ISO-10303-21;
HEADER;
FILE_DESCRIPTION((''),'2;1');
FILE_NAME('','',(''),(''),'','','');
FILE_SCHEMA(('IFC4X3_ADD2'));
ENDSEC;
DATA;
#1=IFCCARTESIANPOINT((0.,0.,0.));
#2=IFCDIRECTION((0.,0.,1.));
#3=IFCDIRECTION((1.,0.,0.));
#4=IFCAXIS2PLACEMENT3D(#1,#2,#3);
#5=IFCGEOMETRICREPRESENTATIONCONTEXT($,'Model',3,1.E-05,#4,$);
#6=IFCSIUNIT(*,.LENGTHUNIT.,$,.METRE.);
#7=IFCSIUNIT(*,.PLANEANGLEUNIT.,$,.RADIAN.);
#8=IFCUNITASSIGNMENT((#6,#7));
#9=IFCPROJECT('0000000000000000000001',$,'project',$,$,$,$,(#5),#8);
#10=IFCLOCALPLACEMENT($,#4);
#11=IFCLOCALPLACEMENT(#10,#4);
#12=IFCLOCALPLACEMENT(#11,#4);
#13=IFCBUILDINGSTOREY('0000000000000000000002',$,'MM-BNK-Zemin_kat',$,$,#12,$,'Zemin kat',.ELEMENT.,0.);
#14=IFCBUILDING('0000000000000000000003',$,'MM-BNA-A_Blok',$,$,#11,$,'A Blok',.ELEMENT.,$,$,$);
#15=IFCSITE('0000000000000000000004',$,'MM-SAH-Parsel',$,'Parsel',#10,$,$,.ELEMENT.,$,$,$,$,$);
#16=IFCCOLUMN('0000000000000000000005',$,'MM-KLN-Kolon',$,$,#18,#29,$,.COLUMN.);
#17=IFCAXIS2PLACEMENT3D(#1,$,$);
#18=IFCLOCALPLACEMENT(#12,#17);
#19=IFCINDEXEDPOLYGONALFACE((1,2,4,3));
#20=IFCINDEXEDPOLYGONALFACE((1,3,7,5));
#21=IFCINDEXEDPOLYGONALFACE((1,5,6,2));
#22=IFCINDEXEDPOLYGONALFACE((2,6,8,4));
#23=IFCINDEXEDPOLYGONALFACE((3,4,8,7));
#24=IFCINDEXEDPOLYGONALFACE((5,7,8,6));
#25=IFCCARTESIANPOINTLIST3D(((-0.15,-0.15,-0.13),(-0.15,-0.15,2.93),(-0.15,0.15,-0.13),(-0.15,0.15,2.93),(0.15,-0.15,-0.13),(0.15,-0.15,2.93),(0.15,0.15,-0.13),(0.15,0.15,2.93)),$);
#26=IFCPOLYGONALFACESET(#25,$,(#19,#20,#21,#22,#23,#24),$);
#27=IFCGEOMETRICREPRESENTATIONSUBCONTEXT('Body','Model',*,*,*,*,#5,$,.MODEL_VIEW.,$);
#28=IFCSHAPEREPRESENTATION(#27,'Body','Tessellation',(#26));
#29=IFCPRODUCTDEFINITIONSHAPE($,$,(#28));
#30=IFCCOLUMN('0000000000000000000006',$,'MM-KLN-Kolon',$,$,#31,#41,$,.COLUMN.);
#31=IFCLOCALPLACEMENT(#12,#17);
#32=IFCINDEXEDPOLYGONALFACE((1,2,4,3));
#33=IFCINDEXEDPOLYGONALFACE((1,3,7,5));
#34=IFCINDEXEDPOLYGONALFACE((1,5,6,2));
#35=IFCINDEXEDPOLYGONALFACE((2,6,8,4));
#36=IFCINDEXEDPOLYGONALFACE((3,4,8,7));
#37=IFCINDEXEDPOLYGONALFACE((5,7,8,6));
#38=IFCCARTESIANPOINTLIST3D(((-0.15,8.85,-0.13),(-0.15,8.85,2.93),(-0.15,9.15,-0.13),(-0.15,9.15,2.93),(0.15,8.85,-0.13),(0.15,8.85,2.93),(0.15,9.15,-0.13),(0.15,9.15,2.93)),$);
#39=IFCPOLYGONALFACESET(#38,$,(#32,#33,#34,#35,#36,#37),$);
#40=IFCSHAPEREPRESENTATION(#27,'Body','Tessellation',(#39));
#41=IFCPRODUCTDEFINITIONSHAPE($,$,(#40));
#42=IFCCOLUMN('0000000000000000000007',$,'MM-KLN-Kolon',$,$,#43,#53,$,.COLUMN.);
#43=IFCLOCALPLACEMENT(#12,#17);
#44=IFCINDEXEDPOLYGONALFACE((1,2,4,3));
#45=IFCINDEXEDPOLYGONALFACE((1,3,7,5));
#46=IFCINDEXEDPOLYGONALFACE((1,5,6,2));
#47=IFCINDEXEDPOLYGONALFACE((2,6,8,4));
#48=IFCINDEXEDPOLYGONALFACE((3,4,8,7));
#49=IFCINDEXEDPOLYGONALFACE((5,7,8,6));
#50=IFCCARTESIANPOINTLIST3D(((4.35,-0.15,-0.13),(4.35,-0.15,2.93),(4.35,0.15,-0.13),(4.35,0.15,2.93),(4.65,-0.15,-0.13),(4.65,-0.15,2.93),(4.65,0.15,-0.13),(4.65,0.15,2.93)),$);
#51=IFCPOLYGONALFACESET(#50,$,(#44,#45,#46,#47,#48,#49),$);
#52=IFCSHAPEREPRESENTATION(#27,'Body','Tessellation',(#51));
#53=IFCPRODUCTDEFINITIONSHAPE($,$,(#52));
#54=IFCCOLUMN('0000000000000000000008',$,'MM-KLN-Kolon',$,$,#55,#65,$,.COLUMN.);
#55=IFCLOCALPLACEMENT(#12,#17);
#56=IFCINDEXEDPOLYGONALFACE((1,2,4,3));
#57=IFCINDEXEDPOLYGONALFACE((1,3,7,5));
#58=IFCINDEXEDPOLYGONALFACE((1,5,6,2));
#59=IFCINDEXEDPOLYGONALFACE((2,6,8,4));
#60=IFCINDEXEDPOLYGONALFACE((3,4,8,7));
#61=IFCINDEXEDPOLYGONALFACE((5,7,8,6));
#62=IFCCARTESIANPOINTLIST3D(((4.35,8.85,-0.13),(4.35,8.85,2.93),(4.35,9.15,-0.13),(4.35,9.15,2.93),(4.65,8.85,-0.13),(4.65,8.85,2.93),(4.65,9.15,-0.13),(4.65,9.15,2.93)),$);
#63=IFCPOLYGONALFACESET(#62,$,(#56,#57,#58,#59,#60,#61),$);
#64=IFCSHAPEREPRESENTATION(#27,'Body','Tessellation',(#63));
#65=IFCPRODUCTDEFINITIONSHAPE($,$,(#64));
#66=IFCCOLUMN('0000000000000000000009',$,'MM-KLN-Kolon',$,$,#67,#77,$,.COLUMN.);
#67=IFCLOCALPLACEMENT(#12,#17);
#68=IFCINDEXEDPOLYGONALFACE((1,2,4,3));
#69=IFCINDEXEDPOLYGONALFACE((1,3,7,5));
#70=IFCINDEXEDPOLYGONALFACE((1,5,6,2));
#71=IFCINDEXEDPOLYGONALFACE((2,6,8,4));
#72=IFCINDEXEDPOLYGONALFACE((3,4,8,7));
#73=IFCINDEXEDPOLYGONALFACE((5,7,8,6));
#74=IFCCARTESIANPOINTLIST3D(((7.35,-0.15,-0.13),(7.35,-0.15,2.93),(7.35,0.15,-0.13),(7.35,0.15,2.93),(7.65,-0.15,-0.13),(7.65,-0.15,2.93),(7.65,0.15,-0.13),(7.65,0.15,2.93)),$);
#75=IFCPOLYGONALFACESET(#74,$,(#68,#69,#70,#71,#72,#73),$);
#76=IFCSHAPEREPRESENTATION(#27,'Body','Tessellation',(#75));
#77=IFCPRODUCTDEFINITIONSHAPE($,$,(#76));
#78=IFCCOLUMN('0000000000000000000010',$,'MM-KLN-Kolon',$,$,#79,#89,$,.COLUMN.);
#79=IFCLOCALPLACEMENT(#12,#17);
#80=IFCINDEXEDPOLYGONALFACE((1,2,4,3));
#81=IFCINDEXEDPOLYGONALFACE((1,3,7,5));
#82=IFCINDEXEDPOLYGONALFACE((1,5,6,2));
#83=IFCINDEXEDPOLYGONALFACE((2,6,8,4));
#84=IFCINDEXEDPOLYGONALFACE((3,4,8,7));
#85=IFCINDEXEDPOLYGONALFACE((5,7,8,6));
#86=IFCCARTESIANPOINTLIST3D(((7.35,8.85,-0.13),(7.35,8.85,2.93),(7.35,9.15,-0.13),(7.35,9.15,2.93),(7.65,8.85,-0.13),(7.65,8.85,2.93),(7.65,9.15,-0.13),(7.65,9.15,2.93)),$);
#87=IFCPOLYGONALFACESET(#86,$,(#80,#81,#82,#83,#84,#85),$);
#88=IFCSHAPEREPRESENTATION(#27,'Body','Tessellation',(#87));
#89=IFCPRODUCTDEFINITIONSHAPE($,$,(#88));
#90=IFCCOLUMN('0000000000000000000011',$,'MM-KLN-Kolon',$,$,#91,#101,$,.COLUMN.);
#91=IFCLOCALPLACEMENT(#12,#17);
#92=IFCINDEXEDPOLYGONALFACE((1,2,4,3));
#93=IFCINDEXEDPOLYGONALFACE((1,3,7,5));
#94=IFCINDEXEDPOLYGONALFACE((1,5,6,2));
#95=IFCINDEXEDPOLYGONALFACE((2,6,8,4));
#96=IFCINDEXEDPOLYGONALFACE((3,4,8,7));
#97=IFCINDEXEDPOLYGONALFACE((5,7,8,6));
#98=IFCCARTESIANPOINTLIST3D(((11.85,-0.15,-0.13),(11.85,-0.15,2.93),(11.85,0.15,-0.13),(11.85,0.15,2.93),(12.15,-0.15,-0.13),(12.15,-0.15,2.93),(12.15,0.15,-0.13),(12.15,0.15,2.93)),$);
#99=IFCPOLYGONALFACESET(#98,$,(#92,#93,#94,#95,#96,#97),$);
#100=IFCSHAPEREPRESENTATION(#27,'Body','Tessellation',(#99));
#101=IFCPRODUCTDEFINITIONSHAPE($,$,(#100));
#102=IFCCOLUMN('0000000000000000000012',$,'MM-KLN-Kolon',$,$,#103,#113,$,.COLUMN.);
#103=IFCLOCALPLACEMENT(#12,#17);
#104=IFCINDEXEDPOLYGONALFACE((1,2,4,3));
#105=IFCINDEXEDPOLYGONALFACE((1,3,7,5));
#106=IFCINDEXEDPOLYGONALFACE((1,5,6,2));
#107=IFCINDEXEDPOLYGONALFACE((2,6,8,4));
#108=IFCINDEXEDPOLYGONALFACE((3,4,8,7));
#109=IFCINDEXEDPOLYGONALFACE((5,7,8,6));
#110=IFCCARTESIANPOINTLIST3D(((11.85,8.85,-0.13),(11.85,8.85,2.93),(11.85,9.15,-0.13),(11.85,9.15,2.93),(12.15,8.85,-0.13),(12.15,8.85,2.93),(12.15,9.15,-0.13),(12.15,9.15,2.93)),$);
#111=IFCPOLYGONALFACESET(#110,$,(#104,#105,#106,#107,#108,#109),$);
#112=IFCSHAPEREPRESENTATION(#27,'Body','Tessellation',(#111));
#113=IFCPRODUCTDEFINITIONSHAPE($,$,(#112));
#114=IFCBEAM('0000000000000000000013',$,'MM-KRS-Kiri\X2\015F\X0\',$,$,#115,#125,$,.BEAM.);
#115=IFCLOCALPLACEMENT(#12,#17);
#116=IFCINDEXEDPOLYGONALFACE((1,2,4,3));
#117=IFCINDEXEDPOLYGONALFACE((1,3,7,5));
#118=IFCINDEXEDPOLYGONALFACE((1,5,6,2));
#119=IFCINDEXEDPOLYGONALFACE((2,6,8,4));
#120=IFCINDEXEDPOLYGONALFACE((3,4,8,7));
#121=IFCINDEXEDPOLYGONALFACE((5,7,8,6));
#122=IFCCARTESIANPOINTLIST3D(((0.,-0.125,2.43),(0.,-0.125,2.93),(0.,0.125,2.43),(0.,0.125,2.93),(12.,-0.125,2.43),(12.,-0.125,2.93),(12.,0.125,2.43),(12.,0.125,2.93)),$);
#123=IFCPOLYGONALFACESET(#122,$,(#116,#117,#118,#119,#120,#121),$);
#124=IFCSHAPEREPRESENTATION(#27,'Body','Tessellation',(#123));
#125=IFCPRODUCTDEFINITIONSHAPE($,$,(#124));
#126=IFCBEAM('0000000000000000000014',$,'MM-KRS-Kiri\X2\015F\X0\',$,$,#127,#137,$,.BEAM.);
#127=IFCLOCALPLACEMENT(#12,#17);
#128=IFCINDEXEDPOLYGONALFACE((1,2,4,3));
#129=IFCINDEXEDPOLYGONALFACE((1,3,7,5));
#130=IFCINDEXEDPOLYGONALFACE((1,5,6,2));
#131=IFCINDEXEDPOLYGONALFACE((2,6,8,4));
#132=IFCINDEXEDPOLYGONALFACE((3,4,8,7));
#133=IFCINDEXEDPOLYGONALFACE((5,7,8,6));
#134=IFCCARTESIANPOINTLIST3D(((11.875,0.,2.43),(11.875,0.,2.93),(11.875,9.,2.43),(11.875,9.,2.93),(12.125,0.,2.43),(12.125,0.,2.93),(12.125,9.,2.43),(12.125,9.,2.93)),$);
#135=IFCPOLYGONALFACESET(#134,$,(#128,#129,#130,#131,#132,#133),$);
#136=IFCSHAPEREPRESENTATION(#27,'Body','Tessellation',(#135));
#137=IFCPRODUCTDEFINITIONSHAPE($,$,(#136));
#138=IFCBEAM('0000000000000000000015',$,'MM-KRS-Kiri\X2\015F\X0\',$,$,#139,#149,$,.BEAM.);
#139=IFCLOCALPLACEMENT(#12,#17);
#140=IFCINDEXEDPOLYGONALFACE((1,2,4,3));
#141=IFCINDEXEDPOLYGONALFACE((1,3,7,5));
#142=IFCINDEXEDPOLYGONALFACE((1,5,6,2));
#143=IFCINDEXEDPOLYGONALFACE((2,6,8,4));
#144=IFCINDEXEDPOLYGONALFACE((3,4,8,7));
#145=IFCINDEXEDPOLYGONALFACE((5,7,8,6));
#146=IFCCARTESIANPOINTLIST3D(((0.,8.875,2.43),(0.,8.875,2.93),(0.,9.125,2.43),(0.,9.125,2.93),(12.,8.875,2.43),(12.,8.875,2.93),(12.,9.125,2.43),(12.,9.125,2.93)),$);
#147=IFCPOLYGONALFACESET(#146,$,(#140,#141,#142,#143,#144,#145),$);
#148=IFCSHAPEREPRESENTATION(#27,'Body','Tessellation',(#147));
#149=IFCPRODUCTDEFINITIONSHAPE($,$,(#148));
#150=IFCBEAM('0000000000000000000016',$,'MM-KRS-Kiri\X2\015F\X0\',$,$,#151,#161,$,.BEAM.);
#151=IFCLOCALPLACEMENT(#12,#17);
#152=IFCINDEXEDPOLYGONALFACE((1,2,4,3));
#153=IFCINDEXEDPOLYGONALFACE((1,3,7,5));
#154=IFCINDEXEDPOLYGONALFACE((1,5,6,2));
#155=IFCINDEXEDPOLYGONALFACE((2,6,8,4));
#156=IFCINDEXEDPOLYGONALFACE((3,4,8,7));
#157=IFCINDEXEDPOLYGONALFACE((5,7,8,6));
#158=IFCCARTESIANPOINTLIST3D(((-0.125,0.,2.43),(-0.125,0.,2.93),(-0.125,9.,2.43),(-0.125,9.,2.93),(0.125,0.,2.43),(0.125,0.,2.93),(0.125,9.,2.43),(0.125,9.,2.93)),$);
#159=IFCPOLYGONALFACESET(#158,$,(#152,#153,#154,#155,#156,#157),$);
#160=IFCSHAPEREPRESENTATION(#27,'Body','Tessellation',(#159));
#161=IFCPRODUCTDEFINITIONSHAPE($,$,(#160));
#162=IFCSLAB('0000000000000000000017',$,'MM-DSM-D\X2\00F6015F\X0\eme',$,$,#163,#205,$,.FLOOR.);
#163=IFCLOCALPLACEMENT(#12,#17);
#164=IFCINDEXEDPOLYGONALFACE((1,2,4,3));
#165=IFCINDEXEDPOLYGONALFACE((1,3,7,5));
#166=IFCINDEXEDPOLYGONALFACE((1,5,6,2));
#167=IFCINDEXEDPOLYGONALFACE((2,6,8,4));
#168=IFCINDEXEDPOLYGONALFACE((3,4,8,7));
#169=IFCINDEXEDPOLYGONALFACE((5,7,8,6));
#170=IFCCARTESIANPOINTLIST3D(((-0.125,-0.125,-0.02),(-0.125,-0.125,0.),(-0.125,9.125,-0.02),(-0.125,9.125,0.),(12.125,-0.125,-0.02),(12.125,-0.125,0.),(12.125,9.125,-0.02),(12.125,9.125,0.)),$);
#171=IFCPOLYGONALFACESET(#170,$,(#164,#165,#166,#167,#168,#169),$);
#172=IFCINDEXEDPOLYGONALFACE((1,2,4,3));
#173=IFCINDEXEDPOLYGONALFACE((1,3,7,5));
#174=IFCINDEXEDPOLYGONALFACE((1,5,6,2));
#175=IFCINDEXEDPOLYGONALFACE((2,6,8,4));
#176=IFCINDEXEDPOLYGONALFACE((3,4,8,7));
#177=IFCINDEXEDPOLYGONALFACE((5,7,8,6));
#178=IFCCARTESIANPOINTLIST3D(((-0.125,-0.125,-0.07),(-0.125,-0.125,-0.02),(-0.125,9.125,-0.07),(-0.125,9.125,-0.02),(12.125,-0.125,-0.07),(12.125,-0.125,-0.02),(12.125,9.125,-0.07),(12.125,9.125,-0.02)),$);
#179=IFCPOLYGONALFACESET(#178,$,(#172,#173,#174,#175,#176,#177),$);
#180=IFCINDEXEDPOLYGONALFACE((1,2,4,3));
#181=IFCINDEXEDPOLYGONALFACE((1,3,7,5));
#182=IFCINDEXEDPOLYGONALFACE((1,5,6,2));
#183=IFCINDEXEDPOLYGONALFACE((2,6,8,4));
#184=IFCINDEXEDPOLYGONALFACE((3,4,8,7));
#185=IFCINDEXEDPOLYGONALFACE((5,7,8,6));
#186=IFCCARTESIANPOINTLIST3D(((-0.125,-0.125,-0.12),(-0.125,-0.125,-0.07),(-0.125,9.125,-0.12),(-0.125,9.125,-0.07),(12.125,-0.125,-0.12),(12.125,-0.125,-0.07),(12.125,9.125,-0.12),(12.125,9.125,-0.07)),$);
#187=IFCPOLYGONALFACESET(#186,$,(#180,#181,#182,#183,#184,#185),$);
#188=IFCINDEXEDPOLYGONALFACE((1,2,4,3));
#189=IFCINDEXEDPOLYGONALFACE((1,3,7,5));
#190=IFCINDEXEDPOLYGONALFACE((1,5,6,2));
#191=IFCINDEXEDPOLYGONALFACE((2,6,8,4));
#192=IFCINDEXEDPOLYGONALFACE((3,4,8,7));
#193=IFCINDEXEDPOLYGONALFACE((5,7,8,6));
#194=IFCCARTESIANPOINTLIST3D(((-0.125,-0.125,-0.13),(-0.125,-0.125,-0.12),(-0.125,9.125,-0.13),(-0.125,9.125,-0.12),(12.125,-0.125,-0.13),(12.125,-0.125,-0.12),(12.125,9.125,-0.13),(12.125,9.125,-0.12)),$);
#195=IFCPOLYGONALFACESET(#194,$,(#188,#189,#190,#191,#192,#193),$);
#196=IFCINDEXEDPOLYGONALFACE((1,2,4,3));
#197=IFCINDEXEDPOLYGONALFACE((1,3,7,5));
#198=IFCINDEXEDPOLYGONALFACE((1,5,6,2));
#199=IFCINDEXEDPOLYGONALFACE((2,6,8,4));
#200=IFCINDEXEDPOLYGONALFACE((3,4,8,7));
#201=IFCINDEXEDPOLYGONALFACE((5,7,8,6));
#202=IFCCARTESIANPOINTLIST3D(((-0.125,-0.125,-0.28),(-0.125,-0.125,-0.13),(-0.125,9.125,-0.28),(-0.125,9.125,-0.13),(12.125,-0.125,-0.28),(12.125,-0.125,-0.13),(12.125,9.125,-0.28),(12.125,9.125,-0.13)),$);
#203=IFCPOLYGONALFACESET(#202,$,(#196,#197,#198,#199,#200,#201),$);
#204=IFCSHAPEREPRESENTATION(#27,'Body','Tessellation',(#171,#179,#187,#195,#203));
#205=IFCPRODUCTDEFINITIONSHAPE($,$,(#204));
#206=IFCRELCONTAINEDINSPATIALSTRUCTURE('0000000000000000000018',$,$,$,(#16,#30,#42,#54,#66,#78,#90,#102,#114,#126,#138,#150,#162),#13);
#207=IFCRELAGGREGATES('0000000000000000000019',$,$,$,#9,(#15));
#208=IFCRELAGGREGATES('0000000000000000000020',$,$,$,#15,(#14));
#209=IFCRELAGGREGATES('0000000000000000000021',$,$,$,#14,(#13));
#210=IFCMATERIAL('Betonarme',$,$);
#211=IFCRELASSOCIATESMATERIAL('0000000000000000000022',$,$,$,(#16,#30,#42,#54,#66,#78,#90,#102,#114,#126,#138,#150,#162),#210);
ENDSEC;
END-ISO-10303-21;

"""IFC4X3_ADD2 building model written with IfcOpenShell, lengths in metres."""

from ifc_helpers import new_model, si_unit, frame, origin_with_axes, place, context, subcontext, project, spatial, polyline, outline, extrude, material, element, save


model = new_model("IFC4X3_ADD2")

# Units and contexts
model_context = context("Model", 3, precision=1e-05, world=origin_with_axes())
body_context = subcontext(model_context, "Body", "Model", "MODEL_VIEW")
ifc_project = project(units=[si_unit("LENGTHUNIT", "METRE"), si_unit("PLANEANGLEUNIT", "RADIAN")], contexts=[model_context])

# Site, building, storey
site_placement = place(None, origin_with_axes())
site = spatial("IfcSite", under=ifc_project, at=site_placement, Name="MM-SAH-Parsel", ObjectType="Parsel", CompositionType="ELEMENT")
building_placement = place(site_placement, origin_with_axes())
building = spatial("IfcBuilding", under=site, at=building_placement, Name="MM-BNA-A_Blok", LongName="A Blok", CompositionType="ELEMENT")
storey_placement = place(building_placement, origin_with_axes())
storey = spatial("IfcBuildingStorey", under=building, at=storey_placement, Name="MM-BNK-Zemin_kat", LongName="Zemin kat", CompositionType="ELEMENT", Elevation=0.0)

# Columns
ifc_material_1 = material(Name="Betonarme")
column_1_placement = place(storey_placement, origin_with_axes())
element("IfcColumn", 1, at=column_1_placement, inside=storey, material=ifc_material_1, Name="MM-KLN-Kolon", PredefinedType="COLUMN", context=body_context, shape_type="SweptSolid", body=[
    extrude(outline(polyline([(-0.15, -0.15), (0.15, -0.15), (0.15, 0.15), (-0.15, 0.15), (-0.15, -0.15)])), frame((0.0, 0.0, -0.13)), (0.0, 0.0, 1.0), 3.06),
])
column_2_placement = place(storey_placement, origin_with_axes())
element("IfcColumn", 2, at=column_2_placement, inside=storey, material=ifc_material_1, Name="MM-KLN-Kolon", PredefinedType="COLUMN", context=body_context, shape_type="SweptSolid", body=[
    extrude(outline(polyline([(-0.15, 8.85), (0.15, 8.85), (0.15, 9.15), (-0.15, 9.15), (-0.15, 8.85)])), frame((0.0, 0.0, -0.13)), (0.0, 0.0, 1.0), 3.06),
])
column_3_placement = place(storey_placement, origin_with_axes())
element("IfcColumn", 3, at=column_3_placement, inside=storey, material=ifc_material_1, Name="MM-KLN-Kolon", PredefinedType="COLUMN", context=body_context, shape_type="SweptSolid", body=[
    extrude(outline(polyline([(4.35, -0.15), (4.65, -0.15), (4.65, 0.15), (4.35, 0.15), (4.35, -0.15)])), frame((0.0, 0.0, -0.13)), (0.0, 0.0, 1.0), 3.06),
])
column_4_placement = place(storey_placement, origin_with_axes())
element("IfcColumn", 4, at=column_4_placement, inside=storey, material=ifc_material_1, Name="MM-KLN-Kolon", PredefinedType="COLUMN", context=body_context, shape_type="SweptSolid", body=[
    extrude(outline(polyline([(4.35, 8.85), (4.65, 8.85), (4.65, 9.15), (4.35, 9.15), (4.35, 8.85)])), frame((0.0, 0.0, -0.13)), (0.0, 0.0, 1.0), 3.06),
])
column_5_placement = place(storey_placement, origin_with_axes())
element("IfcColumn", 5, at=column_5_placement, inside=storey, material=ifc_material_1, Name="MM-KLN-Kolon", PredefinedType="COLUMN", context=body_context, shape_type="SweptSolid", body=[
    extrude(outline(polyline([(7.35, -0.15), (7.65, -0.15), (7.65, 0.15), (7.35, 0.15), (7.35, -0.15)])), frame((0.0, 0.0, -0.13)), (0.0, 0.0, 1.0), 3.06),
])
column_6_placement = place(storey_placement, origin_with_axes())
element("IfcColumn", 6, at=column_6_placement, inside=storey, material=ifc_material_1, Name="MM-KLN-Kolon", PredefinedType="COLUMN", context=body_context, shape_type="SweptSolid", body=[
    extrude(outline(polyline([(7.35, 8.85), (7.65, 8.85), (7.65, 9.15), (7.35, 9.15), (7.35, 8.85)])), frame((0.0, 0.0, -0.13)), (0.0, 0.0, 1.0), 3.06),
])
column_7_placement = place(storey_placement, origin_with_axes())
element("IfcColumn", 7, at=column_7_placement, inside=storey, material=ifc_material_1, Name="MM-KLN-Kolon", PredefinedType="COLUMN", context=body_context, shape_type="SweptSolid", body=[
    extrude(outline(polyline([(11.85, -0.15), (12.15, -0.15), (12.15, 0.15), (11.85, 0.15), (11.85, -0.15)])), frame((0.0, 0.0, -0.13)), (0.0, 0.0, 1.0), 3.06),
])
column_8_placement = place(storey_placement, origin_with_axes())
element("IfcColumn", 8, at=column_8_placement, inside=storey, material=ifc_material_1, Name="MM-KLN-Kolon", PredefinedType="COLUMN", context=body_context, shape_type="SweptSolid", body=[
    extrude(outline(polyline([(11.85, 8.85), (12.15, 8.85), (12.15, 9.15), (11.85, 9.15), (11.85, 8.85)])), frame((0.0, 0.0, -0.13)), (0.0, 0.0, 1.0), 3.06),
])

# Beams
beam_1_placement = place(storey_placement, origin_with_axes())
element("IfcBeam", 9, at=beam_1_placement, inside=storey, material=ifc_material_1, Name="MM-KRS-Kiriş", PredefinedType="BEAM", context=body_context, shape_type="SweptSolid", body=[
    extrude(outline(polyline([(0.0, 0.125), (12.0, 0.125), (12.0, -0.125), (0.0, -0.125), (0.0, 0.125)])), frame((0.0, 0.0, 2.43)), (0.0, 0.0, 1.0), 0.5),
])
beam_2_placement = place(storey_placement, origin_with_axes())
element("IfcBeam", 10, at=beam_2_placement, inside=storey, material=ifc_material_1, Name="MM-KRS-Kiriş", PredefinedType="BEAM", context=body_context, shape_type="SweptSolid", body=[
    extrude(outline(polyline([(11.875, 0.0), (11.875, 9.0), (12.125, 9.0), (12.125, 0.0), (11.875, 0.0)])), frame((0.0, 0.0, 2.43)), (0.0, 0.0, 1.0), 0.5),
])
beam_3_placement = place(storey_placement, origin_with_axes())
element("IfcBeam", 11, at=beam_3_placement, inside=storey, material=ifc_material_1, Name="MM-KRS-Kiriş", PredefinedType="BEAM", context=body_context, shape_type="SweptSolid", body=[
    extrude(outline(polyline([(12.0, 8.875), (0.0, 8.875), (0.0, 9.125), (12.0, 9.125), (12.0, 8.875)])), frame((0.0, 0.0, 2.43)), (0.0, 0.0, 1.0), 0.5),
])
beam_4_placement = place(storey_placement, origin_with_axes())
element("IfcBeam", 12, at=beam_4_placement, inside=storey, material=ifc_material_1, Name="MM-KRS-Kiriş", PredefinedType="BEAM", context=body_context, shape_type="SweptSolid", body=[
    extrude(outline(polyline([(0.125, 9.0), (0.125, 0.0), (-0.125, 0.0), (-0.125, 9.0), (0.125, 9.0)])), frame((0.0, 0.0, 2.43)), (0.0, 0.0, 1.0), 0.5),
])

# Slab
slab_placement = place(storey_placement, origin_with_axes())
element("IfcSlab", 13, at=slab_placement, inside=storey, material=ifc_material_1, Name="MM-DSM-Döşeme", PredefinedType="FLOOR", context=body_context, shape_type="SweptSolid", body=[
    extrude(outline(polyline([(-0.125, -0.125), (12.125, -0.125), (12.125, 9.125), (-0.125, 9.125), (-0.125, -0.125)])), frame((0.0, 0.0, -0.02)), (0.0, 0.0, 1.0), 0.02),
    extrude(outline(polyline([(-0.125, -0.125), (12.125, -0.125), (12.125, 9.125), (-0.125, 9.125), (-0.125, -0.125)])), frame((0.0, 0.0, -0.07)), (0.0, 0.0, 1.0), 0.05),
    extrude(outline(polyline([(-0.125, -0.125), (12.125, -0.125), (12.125, 9.125), (-0.125, 9.125), (-0.125, -0.125)])), frame((0.0, 0.0, -0.12)), (0.0, 0.0, 1.0), 0.05),
    extrude(outline(polyline([(-0.125, -0.125), (12.125, -0.125), (12.125, 9.125), (-0.125, 9.125), (-0.125, -0.125)])), frame((0.0, 0.0, -0.13)), (0.0, 0.0, 1.0), 0.01),
    extrude(outline(polyline([(-0.125, -0.125), (12.125, -0.125), (12.125, 9.125), (-0.125, 9.125), (-0.125, -0.125)])), frame((0.0, 0.0, -0.28)), (0.0, 0.0, 1.0), 0.15),
])

save(model, "model.ifc")
